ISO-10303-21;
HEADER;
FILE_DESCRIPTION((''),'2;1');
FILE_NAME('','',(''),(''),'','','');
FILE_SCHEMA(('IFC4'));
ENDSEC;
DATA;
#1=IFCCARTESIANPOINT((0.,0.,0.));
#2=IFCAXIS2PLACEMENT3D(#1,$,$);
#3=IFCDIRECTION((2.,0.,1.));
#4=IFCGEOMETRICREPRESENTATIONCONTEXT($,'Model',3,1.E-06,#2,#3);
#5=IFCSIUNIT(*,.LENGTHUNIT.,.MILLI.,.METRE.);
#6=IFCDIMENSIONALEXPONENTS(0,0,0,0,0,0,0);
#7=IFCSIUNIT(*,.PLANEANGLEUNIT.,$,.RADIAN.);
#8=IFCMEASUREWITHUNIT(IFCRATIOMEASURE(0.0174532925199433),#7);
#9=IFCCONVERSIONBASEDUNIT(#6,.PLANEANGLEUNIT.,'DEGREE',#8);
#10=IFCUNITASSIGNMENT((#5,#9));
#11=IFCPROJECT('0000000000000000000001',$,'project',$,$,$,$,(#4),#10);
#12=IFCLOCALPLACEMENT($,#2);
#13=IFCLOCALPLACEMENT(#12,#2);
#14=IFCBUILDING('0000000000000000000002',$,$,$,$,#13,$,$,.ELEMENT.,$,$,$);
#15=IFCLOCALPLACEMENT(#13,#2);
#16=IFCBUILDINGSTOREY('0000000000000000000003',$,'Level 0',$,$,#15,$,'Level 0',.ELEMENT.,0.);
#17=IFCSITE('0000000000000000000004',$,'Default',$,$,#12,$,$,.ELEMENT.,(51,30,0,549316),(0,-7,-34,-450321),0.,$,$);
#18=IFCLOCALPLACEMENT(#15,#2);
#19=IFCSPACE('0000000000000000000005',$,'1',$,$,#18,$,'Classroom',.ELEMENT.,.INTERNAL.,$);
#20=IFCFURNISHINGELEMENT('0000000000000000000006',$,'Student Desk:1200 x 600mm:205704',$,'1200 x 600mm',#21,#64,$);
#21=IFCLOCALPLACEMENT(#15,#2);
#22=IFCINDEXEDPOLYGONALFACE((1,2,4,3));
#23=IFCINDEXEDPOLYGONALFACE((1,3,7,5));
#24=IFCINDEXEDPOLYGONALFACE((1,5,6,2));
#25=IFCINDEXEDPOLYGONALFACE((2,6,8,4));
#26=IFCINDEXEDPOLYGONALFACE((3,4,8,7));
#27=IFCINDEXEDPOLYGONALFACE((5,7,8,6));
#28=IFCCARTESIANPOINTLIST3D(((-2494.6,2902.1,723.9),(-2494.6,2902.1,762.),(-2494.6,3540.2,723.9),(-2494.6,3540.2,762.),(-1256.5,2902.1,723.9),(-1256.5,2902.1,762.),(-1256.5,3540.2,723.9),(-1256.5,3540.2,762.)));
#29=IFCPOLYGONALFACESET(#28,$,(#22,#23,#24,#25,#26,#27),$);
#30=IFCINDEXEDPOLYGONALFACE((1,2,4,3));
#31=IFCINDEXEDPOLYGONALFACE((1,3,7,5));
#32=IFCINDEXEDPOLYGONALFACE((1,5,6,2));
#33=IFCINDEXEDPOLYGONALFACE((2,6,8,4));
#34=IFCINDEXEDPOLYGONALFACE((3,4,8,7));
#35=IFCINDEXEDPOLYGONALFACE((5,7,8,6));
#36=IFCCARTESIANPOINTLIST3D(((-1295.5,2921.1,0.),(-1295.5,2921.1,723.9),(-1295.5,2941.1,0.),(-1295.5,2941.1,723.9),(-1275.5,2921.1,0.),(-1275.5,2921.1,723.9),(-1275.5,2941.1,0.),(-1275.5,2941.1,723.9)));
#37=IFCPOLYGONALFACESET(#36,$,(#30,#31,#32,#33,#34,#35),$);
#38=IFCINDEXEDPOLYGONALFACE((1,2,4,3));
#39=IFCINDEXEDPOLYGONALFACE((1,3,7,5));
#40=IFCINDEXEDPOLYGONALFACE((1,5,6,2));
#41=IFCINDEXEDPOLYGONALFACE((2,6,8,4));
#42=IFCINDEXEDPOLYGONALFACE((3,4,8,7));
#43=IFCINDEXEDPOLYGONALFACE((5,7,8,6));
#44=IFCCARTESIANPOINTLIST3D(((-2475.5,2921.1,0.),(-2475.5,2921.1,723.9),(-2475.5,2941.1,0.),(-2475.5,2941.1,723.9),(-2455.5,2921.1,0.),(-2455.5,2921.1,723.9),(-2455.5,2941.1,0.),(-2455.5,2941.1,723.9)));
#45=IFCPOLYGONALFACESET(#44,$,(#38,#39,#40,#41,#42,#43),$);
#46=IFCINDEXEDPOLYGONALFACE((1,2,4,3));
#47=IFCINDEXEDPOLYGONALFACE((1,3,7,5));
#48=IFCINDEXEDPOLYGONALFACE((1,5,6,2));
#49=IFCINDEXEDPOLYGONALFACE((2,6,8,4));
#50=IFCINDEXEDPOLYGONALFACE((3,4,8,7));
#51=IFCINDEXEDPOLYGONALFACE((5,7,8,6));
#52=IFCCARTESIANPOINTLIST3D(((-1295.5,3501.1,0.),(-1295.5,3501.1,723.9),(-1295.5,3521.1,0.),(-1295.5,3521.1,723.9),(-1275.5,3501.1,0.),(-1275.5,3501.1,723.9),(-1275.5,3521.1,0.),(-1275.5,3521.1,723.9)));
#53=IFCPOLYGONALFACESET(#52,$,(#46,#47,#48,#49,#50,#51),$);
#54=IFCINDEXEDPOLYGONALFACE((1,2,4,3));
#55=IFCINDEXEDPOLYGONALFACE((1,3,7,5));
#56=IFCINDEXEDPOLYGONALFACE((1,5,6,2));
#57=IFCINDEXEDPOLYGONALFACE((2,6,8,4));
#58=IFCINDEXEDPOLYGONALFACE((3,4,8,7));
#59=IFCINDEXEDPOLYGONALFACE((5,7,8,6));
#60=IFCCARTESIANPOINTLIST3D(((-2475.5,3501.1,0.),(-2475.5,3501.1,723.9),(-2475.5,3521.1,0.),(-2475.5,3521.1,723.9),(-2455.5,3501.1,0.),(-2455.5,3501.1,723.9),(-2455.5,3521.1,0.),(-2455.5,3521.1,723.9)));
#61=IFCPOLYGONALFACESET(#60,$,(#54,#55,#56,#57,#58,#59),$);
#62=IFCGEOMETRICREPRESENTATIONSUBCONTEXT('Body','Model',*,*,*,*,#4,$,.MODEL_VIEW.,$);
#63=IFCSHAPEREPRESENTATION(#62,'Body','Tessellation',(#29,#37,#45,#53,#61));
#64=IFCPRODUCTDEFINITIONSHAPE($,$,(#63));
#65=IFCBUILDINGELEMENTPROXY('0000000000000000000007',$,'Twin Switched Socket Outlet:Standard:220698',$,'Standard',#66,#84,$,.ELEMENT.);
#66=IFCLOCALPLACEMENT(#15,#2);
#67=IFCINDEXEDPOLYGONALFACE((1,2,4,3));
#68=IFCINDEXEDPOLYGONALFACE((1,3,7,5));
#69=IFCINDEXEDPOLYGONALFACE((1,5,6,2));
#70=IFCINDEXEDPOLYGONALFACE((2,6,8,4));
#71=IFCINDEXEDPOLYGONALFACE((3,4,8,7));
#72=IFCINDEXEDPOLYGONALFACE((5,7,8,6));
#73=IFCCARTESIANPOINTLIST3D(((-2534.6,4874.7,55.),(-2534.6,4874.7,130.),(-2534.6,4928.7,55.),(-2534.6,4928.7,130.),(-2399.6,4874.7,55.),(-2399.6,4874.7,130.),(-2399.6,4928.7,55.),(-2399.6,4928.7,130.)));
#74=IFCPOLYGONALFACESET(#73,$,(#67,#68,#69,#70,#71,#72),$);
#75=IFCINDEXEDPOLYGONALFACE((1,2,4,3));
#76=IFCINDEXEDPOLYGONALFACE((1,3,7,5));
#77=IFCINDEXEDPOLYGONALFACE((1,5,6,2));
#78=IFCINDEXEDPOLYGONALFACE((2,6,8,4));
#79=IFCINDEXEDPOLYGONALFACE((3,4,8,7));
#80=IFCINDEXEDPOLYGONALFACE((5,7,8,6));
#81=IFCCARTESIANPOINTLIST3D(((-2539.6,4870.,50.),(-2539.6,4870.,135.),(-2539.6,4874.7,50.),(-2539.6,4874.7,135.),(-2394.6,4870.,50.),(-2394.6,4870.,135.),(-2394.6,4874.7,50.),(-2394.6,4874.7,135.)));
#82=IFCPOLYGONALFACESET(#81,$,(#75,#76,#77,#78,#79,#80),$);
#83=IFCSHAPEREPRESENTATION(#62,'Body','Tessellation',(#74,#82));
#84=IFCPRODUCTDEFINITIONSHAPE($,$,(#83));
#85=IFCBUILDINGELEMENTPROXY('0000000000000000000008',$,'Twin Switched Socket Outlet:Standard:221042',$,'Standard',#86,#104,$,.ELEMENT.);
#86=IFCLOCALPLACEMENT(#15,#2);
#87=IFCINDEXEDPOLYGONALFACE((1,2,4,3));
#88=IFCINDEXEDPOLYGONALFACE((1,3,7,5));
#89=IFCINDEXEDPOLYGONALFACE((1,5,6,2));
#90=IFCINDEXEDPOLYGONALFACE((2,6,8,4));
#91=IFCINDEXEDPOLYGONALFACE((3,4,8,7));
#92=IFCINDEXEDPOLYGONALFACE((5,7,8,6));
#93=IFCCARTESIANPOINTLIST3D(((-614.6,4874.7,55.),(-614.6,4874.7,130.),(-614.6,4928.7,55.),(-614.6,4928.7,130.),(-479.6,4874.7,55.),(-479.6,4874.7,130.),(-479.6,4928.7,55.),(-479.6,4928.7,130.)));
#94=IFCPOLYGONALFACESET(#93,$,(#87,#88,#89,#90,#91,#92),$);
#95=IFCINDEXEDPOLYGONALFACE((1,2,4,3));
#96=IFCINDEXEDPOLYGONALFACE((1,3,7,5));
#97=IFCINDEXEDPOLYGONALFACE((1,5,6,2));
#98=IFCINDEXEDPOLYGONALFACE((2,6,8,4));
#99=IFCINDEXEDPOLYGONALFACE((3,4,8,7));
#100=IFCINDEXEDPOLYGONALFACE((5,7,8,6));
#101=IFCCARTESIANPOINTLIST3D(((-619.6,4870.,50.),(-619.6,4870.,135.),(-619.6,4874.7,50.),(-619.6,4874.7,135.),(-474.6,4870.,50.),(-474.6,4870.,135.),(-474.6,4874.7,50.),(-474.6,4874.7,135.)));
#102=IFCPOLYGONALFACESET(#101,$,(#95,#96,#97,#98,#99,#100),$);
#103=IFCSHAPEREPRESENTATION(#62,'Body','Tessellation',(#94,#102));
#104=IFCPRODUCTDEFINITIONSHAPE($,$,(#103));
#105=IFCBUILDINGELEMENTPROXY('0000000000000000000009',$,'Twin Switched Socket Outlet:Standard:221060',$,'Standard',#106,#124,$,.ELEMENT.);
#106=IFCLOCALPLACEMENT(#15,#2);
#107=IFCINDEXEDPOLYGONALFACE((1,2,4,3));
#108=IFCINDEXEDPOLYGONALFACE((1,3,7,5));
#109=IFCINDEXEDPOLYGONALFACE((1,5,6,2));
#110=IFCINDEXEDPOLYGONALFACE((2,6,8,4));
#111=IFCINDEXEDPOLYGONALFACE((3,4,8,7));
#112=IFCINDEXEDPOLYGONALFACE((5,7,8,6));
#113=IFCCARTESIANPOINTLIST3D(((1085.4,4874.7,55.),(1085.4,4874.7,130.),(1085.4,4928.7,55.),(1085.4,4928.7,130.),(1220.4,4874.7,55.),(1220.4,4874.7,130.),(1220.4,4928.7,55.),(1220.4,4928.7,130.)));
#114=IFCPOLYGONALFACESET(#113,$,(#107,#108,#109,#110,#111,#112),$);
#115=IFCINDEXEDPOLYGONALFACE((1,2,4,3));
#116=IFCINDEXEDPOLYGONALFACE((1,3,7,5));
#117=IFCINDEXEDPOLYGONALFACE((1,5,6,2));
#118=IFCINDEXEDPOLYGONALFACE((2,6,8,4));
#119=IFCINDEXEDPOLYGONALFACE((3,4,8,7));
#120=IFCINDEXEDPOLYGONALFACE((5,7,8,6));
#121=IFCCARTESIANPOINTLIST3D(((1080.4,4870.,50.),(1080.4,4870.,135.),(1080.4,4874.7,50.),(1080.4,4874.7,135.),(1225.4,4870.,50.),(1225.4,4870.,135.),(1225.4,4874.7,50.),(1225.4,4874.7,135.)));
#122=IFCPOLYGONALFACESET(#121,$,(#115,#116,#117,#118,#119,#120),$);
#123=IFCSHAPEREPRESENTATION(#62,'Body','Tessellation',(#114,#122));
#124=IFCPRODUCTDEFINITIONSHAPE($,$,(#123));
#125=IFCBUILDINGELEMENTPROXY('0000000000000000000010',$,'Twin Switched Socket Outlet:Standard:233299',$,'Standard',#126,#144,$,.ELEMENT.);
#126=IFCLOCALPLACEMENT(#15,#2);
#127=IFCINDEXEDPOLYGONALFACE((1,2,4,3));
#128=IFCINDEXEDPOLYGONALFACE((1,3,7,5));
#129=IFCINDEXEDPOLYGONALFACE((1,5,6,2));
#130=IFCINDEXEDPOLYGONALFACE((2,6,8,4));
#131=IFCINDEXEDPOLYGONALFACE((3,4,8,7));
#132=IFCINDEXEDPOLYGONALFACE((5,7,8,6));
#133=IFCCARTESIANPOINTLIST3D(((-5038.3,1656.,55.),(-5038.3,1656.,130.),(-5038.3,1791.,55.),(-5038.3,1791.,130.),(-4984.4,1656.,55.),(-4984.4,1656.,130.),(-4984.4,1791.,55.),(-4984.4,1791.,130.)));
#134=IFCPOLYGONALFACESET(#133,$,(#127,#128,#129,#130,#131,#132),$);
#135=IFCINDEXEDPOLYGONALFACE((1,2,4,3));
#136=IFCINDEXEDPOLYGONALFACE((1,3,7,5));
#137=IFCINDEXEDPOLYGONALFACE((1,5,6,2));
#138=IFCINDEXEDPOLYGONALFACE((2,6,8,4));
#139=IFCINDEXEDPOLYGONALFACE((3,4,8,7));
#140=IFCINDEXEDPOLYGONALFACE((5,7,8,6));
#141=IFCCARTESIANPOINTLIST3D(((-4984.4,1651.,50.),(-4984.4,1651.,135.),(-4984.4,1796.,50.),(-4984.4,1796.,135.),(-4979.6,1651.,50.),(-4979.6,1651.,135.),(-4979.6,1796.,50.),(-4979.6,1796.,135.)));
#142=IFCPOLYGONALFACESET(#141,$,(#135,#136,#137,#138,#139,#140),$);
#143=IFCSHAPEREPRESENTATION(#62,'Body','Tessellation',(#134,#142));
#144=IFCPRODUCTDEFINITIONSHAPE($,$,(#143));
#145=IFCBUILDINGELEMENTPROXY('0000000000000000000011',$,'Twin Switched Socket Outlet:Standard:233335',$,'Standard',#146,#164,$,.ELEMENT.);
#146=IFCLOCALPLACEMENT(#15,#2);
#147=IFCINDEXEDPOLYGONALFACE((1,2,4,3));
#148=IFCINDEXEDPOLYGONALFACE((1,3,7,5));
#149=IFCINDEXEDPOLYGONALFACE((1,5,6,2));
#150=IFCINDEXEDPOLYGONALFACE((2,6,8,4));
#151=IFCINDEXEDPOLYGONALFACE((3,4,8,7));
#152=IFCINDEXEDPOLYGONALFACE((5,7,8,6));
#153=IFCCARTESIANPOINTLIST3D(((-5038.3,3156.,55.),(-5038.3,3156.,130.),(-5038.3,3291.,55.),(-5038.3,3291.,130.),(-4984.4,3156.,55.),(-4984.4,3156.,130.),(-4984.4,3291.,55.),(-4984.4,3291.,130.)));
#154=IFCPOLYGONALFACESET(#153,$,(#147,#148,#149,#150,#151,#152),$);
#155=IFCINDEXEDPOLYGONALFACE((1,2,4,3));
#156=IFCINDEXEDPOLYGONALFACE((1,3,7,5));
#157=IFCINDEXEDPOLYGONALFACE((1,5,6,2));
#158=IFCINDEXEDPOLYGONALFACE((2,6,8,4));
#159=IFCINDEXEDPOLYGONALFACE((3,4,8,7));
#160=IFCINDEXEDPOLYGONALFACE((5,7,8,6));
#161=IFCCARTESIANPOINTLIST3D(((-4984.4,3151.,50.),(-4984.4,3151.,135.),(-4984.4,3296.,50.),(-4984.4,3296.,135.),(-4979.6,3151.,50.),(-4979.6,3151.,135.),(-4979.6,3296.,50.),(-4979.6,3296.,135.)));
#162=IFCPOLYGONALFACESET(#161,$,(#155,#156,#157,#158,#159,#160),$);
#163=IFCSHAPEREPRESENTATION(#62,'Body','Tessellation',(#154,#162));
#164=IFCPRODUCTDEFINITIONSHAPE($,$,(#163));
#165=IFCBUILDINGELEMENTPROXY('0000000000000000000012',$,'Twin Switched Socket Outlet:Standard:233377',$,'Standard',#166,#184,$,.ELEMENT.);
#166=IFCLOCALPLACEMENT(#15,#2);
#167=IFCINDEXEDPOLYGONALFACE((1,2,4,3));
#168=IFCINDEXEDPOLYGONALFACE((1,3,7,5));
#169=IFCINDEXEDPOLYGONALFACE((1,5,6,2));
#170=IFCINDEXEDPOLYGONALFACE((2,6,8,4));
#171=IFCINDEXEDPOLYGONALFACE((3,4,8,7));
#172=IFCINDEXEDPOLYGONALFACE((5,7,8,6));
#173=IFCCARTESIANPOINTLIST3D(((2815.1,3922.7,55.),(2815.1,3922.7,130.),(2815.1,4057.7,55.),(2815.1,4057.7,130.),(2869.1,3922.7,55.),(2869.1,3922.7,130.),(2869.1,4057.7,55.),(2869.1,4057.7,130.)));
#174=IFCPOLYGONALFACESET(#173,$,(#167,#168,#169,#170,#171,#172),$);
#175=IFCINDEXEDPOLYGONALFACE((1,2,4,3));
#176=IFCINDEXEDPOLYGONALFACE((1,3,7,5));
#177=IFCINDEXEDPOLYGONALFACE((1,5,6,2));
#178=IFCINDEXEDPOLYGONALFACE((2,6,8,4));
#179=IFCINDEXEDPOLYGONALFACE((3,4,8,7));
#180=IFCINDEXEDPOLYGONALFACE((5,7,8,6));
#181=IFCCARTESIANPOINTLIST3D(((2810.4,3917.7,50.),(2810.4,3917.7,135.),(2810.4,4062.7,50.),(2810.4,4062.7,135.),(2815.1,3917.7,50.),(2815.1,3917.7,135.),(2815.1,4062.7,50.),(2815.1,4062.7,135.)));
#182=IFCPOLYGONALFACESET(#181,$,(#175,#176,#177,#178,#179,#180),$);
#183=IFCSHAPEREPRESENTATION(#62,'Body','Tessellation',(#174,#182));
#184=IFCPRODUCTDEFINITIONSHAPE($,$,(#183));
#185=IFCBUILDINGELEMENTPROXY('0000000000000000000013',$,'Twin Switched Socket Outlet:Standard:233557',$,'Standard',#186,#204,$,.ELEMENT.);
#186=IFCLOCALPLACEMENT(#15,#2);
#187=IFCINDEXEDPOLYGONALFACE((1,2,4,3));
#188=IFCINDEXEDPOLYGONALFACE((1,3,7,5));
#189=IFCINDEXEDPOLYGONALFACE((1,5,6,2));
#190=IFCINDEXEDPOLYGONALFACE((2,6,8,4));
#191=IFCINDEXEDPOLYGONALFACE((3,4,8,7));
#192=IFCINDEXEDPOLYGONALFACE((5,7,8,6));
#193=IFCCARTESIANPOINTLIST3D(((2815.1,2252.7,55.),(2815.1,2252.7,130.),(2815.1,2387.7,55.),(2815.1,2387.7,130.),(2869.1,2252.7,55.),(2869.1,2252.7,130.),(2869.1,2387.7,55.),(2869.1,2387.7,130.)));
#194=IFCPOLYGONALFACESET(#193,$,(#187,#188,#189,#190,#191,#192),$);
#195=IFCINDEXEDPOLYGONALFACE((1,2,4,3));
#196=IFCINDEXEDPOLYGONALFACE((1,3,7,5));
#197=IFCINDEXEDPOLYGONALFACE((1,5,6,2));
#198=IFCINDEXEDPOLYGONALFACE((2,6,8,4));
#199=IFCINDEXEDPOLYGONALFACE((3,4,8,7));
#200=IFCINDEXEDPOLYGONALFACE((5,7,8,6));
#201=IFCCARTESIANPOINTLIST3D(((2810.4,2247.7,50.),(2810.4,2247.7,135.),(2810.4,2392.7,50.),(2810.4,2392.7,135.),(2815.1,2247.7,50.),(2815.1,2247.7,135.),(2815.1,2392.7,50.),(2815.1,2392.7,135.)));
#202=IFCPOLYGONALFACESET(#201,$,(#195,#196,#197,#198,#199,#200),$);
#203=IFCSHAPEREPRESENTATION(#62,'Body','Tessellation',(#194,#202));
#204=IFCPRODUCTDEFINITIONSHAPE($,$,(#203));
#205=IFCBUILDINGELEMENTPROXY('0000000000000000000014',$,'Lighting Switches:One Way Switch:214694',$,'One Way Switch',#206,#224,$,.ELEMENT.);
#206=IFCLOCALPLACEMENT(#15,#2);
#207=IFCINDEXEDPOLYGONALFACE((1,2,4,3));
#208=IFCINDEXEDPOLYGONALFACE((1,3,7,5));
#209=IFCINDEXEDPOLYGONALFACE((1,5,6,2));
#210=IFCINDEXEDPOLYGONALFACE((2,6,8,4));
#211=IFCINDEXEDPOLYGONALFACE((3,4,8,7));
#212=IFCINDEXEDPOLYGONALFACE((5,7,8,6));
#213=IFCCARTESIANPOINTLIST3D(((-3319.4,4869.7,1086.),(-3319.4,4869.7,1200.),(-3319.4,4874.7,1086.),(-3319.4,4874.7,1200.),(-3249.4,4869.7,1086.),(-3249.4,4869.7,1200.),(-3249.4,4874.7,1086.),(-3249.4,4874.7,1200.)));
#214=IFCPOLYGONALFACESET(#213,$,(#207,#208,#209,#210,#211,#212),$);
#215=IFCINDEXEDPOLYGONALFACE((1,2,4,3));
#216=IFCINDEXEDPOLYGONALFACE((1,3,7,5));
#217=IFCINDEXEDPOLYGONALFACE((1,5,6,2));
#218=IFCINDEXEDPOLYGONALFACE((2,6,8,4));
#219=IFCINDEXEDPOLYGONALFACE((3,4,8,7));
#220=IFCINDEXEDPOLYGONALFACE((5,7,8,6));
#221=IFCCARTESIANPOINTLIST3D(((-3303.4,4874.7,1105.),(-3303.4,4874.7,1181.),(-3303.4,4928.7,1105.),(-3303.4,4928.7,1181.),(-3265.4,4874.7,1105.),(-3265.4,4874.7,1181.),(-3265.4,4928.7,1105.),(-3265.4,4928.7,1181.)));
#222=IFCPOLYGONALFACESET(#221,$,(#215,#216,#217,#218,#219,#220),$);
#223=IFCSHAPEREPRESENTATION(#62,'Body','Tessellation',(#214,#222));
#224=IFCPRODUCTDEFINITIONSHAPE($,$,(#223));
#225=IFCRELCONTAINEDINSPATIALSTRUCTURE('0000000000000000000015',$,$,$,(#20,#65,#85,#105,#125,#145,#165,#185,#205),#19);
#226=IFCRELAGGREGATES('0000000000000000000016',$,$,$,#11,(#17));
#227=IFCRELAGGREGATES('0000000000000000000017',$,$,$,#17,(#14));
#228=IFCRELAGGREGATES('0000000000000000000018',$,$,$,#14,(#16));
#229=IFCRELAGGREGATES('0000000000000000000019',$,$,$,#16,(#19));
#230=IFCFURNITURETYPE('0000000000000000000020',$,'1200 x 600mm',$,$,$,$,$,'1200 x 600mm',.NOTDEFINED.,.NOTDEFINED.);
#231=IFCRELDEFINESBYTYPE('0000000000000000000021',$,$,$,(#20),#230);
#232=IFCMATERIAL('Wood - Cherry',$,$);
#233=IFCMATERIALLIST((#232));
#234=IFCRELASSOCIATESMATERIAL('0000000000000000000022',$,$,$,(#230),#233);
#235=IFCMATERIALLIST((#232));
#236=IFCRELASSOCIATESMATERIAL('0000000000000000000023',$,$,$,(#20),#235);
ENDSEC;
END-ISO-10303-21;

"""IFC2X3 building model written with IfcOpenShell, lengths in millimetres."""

from ifc_helpers import new_model, entity, si_unit, converted_unit, direction, frame, frame_2d, origin, origin_2d_with_axis, place, context, subcontext, project, spatial, rectangle, extrude, source, transform, mapped, material, material_list, type_object, type_shapes, element, save


model = new_model("IFC2X3")

# Units and contexts
model_context = context("Model", 3, precision=1e-06, world=origin(), true_north=direction((2.0, 0.0, 1.0)))
body_context = subcontext(model_context, "Body", "Model", "MODEL_VIEW")
ifc_project = project(units=[si_unit("LENGTHUNIT", "METRE", prefix="MILLI"), converted_unit("PLANEANGLEUNIT", "DEGREE", entity("IfcRatioMeasure", 0.0174532925199433), si_unit("PLANEANGLEUNIT", "RADIAN"), dimensions=[0, 0, 0, 0, 0, 0, 0])], contexts=[model_context])

# Site, building, storey
site_placement = place(None, origin())
site = spatial("IfcSite", under=ifc_project, at=site_placement, Name="Default", CompositionType="ELEMENT", RefLatitude=(51, 30, 0, 549316), RefLongitude=(0, -7, -34, -450321), RefElevation=0.0)
building_placement = place(site_placement, origin())
building = spatial("IfcBuilding", under=site, at=building_placement, CompositionType="ELEMENT")
storey_placement = place(building_placement, origin())
storey = spatial("IfcBuildingStorey", under=building, at=storey_placement, Name="Level 0", LongName="Level 0", CompositionType="ELEMENT", Elevation=0.0)

# Shared definitions
space_placement = place(storey_placement, origin())
space = spatial("IfcSpace", under=storey, at=space_placement, Name="1", LongName="Classroom", CompositionType="ELEMENT", InteriorOrExteriorSpace="INTERNAL")

# Furnishing element
ifc_material_1 = material(Name="Wood - Cherry")
ifc_material_list_1 = material_list([ifc_material_1])
furniture_type = type_object("IfcFurnitureType", Name="1200 x 600mm", ElementType="1200 x 600mm", AssemblyPlace="NOTDEFINED", material=ifc_material_list_1)
shared_shape_1 = source(origin(), body_context, "Body", "SweptSolid", [
    extrude(rectangle(XDim=1238.1, YDim=638.1, at=origin_2d_with_axis()), frame((600.0, 300.0, 723.9), z_axis=(0.0, 0.0, 1.0), x_axis=(-1.0, 0.0, 0.0)), (0.0, 0.0, 1.0), 38.1),
    extrude(rectangle(XDim=20.0, YDim=20.0, at=origin_2d_with_axis()), frame((1190.0, 10.0, 0.0)), (0.0, 0.0, 1.0), 723.9),
    extrude(rectangle(XDim=20.0, YDim=20.0, at=frame_2d((0.0, 0.0), x_axis=(1.0, 0.0))), frame((10.0, 10.0, 0.0), z_axis=(0.0, 0.0, 1.0), x_axis=(0.0, 1.0, 0.0)), (0.0, 0.0, 1.0), 723.9),
    extrude(rectangle(XDim=20.0, YDim=20.0, at=frame_2d((0.0, 0.0), x_axis=(1.0, 0.0))), frame((1190.0, 590.0, 0.0), z_axis=(0.0, 0.0, 1.0), x_axis=(0.0, -1.0, 0.0)), (0.0, 0.0, 1.0), 723.9),
    extrude(rectangle(XDim=20.0, YDim=20.0, at=origin_2d_with_axis()), frame((10.0, 590.0, 0.0), z_axis=(0.0, 0.0, 1.0), x_axis=(-1.0, 0.0, 0.0)), (0.0, 0.0, 1.0), 723.9),
])
type_shapes(furniture_type, [shared_shape_1])
ifc_material_list_2 = material_list([ifc_material_1])
furnishing_1_placement = place(space_placement, frame((-2475.5, 2921.1, 0.0)))
element("IfcFurnishingElement", 1, at=furnishing_1_placement, inside=space, type_object=furniture_type, material=ifc_material_list_2, Name="Student Desk:1200 x 600mm:205704", ObjectType="1200 x 600mm", context=body_context, shape_type="MappedRepresentation", body=[
    mapped(shared_shape_1, transform((0.0, 0.0, 0.0), scale=1.0)),
])

# Building element proxies
shared_shape_2 = source(origin(), body_context, "Body", "SweptSolid", [
    extrude(rectangle(XDim=135.0, YDim=75.0, at=origin_2d_with_axis()), frame((0.0, 0.0, -54.0), z_axis=(0.0, 0.0, 1.0), x_axis=(-1.0, 0.0, 0.0)), (0.0, 0.0, 1.0), 54.0),
    extrude(rectangle(XDim=145.0, YDim=85.0, at=origin_2d_with_axis()), frame((0.0, 0.0, 0.0), z_axis=(0.0, 0.0, 1.0), x_axis=(-1.0, 0.0, 0.0)), (0.0, 0.0, 1.0), 4.8),
])
for number, where, z_axis, x_axis, name in (
    (2, (-2467.1, 4874.7, 92.5), (0.0, -1.0, 0.0), (1.0, 0.0, 0.0), "Twin Switched Socket Outlet:Standard:220698"),
    (3, (-547.1, 4874.7, 92.5), (0.0, -1.0, 0.0), (1.0, 0.0, 0.0), "Twin Switched Socket Outlet:Standard:221042"),
    (4, (1152.9, 4874.7, 92.5), (0.0, -1.0, 0.0), (1.0, 0.0, 0.0), "Twin Switched Socket Outlet:Standard:221060"),
    (5, (-4984.4, 1723.5, 92.5), (1.0, 0.0, 0.0), (0.0, 1.0, 0.0), "Twin Switched Socket Outlet:Standard:233299"),
    (6, (-4984.4, 3223.5, 92.5), (1.0, 0.0, 0.0), (0.0, 1.0, 0.0), "Twin Switched Socket Outlet:Standard:233335"),
    (7, (2815.1, 3990.2, 92.5), (-1.0, 0.0, 0.0), (0.0, -1.0, 0.0), "Twin Switched Socket Outlet:Standard:233377"),
    (8, (2815.1, 2320.2, 92.5), (-1.0, 0.0, 0.0), (0.0, -1.0, 0.0), "Twin Switched Socket Outlet:Standard:233557"),
):
    element("IfcBuildingElementProxy", number, at=place(space_placement, frame(where, z_axis=z_axis, x_axis=x_axis)), inside=space, Name=name, ObjectType="Standard", CompositionType="ELEMENT", context=body_context, shape_type="MappedRepresentation", body=[
        mapped(shared_shape_2, transform((0.0, 0.0, 0.0), scale=1.0)),
    ])
shared_shape_3 = source(origin(), body_context, "Body", "SweptSolid", [
    extrude(rectangle(XDim=114.0, YDim=70.0, at=origin_2d_with_axis()), frame((0.0, -57.0, 0.0), z_axis=(0.0, 0.0, 1.0), x_axis=(0.0, 1.0, 0.0)), (0.0, 0.0, 1.0), 5.0),
    extrude(rectangle(XDim=76.0, YDim=38.0, at=origin_2d_with_axis()), frame((0.0, -57.0, -54.0), z_axis=(0.0, 0.0, 1.0), x_axis=(0.0, 1.0, 0.0)), (0.0, 0.0, 1.0), 54.0),
])
proxy_placement = place(space_placement, frame((-3284.4, 4874.7, 1200.0), z_axis=(0.0, -1.0, 0.0), x_axis=(1.0, 0.0, 0.0)))
element("IfcBuildingElementProxy", 9, at=proxy_placement, inside=space, Name="Lighting Switches:One Way Switch:214694", ObjectType="One Way Switch", CompositionType="ELEMENT", context=body_context, shape_type="MappedRepresentation", body=[
    mapped(shared_shape_3, transform((0.0, 0.0, 0.0), scale=1.0)),
])

save(model, "model.ifc")
